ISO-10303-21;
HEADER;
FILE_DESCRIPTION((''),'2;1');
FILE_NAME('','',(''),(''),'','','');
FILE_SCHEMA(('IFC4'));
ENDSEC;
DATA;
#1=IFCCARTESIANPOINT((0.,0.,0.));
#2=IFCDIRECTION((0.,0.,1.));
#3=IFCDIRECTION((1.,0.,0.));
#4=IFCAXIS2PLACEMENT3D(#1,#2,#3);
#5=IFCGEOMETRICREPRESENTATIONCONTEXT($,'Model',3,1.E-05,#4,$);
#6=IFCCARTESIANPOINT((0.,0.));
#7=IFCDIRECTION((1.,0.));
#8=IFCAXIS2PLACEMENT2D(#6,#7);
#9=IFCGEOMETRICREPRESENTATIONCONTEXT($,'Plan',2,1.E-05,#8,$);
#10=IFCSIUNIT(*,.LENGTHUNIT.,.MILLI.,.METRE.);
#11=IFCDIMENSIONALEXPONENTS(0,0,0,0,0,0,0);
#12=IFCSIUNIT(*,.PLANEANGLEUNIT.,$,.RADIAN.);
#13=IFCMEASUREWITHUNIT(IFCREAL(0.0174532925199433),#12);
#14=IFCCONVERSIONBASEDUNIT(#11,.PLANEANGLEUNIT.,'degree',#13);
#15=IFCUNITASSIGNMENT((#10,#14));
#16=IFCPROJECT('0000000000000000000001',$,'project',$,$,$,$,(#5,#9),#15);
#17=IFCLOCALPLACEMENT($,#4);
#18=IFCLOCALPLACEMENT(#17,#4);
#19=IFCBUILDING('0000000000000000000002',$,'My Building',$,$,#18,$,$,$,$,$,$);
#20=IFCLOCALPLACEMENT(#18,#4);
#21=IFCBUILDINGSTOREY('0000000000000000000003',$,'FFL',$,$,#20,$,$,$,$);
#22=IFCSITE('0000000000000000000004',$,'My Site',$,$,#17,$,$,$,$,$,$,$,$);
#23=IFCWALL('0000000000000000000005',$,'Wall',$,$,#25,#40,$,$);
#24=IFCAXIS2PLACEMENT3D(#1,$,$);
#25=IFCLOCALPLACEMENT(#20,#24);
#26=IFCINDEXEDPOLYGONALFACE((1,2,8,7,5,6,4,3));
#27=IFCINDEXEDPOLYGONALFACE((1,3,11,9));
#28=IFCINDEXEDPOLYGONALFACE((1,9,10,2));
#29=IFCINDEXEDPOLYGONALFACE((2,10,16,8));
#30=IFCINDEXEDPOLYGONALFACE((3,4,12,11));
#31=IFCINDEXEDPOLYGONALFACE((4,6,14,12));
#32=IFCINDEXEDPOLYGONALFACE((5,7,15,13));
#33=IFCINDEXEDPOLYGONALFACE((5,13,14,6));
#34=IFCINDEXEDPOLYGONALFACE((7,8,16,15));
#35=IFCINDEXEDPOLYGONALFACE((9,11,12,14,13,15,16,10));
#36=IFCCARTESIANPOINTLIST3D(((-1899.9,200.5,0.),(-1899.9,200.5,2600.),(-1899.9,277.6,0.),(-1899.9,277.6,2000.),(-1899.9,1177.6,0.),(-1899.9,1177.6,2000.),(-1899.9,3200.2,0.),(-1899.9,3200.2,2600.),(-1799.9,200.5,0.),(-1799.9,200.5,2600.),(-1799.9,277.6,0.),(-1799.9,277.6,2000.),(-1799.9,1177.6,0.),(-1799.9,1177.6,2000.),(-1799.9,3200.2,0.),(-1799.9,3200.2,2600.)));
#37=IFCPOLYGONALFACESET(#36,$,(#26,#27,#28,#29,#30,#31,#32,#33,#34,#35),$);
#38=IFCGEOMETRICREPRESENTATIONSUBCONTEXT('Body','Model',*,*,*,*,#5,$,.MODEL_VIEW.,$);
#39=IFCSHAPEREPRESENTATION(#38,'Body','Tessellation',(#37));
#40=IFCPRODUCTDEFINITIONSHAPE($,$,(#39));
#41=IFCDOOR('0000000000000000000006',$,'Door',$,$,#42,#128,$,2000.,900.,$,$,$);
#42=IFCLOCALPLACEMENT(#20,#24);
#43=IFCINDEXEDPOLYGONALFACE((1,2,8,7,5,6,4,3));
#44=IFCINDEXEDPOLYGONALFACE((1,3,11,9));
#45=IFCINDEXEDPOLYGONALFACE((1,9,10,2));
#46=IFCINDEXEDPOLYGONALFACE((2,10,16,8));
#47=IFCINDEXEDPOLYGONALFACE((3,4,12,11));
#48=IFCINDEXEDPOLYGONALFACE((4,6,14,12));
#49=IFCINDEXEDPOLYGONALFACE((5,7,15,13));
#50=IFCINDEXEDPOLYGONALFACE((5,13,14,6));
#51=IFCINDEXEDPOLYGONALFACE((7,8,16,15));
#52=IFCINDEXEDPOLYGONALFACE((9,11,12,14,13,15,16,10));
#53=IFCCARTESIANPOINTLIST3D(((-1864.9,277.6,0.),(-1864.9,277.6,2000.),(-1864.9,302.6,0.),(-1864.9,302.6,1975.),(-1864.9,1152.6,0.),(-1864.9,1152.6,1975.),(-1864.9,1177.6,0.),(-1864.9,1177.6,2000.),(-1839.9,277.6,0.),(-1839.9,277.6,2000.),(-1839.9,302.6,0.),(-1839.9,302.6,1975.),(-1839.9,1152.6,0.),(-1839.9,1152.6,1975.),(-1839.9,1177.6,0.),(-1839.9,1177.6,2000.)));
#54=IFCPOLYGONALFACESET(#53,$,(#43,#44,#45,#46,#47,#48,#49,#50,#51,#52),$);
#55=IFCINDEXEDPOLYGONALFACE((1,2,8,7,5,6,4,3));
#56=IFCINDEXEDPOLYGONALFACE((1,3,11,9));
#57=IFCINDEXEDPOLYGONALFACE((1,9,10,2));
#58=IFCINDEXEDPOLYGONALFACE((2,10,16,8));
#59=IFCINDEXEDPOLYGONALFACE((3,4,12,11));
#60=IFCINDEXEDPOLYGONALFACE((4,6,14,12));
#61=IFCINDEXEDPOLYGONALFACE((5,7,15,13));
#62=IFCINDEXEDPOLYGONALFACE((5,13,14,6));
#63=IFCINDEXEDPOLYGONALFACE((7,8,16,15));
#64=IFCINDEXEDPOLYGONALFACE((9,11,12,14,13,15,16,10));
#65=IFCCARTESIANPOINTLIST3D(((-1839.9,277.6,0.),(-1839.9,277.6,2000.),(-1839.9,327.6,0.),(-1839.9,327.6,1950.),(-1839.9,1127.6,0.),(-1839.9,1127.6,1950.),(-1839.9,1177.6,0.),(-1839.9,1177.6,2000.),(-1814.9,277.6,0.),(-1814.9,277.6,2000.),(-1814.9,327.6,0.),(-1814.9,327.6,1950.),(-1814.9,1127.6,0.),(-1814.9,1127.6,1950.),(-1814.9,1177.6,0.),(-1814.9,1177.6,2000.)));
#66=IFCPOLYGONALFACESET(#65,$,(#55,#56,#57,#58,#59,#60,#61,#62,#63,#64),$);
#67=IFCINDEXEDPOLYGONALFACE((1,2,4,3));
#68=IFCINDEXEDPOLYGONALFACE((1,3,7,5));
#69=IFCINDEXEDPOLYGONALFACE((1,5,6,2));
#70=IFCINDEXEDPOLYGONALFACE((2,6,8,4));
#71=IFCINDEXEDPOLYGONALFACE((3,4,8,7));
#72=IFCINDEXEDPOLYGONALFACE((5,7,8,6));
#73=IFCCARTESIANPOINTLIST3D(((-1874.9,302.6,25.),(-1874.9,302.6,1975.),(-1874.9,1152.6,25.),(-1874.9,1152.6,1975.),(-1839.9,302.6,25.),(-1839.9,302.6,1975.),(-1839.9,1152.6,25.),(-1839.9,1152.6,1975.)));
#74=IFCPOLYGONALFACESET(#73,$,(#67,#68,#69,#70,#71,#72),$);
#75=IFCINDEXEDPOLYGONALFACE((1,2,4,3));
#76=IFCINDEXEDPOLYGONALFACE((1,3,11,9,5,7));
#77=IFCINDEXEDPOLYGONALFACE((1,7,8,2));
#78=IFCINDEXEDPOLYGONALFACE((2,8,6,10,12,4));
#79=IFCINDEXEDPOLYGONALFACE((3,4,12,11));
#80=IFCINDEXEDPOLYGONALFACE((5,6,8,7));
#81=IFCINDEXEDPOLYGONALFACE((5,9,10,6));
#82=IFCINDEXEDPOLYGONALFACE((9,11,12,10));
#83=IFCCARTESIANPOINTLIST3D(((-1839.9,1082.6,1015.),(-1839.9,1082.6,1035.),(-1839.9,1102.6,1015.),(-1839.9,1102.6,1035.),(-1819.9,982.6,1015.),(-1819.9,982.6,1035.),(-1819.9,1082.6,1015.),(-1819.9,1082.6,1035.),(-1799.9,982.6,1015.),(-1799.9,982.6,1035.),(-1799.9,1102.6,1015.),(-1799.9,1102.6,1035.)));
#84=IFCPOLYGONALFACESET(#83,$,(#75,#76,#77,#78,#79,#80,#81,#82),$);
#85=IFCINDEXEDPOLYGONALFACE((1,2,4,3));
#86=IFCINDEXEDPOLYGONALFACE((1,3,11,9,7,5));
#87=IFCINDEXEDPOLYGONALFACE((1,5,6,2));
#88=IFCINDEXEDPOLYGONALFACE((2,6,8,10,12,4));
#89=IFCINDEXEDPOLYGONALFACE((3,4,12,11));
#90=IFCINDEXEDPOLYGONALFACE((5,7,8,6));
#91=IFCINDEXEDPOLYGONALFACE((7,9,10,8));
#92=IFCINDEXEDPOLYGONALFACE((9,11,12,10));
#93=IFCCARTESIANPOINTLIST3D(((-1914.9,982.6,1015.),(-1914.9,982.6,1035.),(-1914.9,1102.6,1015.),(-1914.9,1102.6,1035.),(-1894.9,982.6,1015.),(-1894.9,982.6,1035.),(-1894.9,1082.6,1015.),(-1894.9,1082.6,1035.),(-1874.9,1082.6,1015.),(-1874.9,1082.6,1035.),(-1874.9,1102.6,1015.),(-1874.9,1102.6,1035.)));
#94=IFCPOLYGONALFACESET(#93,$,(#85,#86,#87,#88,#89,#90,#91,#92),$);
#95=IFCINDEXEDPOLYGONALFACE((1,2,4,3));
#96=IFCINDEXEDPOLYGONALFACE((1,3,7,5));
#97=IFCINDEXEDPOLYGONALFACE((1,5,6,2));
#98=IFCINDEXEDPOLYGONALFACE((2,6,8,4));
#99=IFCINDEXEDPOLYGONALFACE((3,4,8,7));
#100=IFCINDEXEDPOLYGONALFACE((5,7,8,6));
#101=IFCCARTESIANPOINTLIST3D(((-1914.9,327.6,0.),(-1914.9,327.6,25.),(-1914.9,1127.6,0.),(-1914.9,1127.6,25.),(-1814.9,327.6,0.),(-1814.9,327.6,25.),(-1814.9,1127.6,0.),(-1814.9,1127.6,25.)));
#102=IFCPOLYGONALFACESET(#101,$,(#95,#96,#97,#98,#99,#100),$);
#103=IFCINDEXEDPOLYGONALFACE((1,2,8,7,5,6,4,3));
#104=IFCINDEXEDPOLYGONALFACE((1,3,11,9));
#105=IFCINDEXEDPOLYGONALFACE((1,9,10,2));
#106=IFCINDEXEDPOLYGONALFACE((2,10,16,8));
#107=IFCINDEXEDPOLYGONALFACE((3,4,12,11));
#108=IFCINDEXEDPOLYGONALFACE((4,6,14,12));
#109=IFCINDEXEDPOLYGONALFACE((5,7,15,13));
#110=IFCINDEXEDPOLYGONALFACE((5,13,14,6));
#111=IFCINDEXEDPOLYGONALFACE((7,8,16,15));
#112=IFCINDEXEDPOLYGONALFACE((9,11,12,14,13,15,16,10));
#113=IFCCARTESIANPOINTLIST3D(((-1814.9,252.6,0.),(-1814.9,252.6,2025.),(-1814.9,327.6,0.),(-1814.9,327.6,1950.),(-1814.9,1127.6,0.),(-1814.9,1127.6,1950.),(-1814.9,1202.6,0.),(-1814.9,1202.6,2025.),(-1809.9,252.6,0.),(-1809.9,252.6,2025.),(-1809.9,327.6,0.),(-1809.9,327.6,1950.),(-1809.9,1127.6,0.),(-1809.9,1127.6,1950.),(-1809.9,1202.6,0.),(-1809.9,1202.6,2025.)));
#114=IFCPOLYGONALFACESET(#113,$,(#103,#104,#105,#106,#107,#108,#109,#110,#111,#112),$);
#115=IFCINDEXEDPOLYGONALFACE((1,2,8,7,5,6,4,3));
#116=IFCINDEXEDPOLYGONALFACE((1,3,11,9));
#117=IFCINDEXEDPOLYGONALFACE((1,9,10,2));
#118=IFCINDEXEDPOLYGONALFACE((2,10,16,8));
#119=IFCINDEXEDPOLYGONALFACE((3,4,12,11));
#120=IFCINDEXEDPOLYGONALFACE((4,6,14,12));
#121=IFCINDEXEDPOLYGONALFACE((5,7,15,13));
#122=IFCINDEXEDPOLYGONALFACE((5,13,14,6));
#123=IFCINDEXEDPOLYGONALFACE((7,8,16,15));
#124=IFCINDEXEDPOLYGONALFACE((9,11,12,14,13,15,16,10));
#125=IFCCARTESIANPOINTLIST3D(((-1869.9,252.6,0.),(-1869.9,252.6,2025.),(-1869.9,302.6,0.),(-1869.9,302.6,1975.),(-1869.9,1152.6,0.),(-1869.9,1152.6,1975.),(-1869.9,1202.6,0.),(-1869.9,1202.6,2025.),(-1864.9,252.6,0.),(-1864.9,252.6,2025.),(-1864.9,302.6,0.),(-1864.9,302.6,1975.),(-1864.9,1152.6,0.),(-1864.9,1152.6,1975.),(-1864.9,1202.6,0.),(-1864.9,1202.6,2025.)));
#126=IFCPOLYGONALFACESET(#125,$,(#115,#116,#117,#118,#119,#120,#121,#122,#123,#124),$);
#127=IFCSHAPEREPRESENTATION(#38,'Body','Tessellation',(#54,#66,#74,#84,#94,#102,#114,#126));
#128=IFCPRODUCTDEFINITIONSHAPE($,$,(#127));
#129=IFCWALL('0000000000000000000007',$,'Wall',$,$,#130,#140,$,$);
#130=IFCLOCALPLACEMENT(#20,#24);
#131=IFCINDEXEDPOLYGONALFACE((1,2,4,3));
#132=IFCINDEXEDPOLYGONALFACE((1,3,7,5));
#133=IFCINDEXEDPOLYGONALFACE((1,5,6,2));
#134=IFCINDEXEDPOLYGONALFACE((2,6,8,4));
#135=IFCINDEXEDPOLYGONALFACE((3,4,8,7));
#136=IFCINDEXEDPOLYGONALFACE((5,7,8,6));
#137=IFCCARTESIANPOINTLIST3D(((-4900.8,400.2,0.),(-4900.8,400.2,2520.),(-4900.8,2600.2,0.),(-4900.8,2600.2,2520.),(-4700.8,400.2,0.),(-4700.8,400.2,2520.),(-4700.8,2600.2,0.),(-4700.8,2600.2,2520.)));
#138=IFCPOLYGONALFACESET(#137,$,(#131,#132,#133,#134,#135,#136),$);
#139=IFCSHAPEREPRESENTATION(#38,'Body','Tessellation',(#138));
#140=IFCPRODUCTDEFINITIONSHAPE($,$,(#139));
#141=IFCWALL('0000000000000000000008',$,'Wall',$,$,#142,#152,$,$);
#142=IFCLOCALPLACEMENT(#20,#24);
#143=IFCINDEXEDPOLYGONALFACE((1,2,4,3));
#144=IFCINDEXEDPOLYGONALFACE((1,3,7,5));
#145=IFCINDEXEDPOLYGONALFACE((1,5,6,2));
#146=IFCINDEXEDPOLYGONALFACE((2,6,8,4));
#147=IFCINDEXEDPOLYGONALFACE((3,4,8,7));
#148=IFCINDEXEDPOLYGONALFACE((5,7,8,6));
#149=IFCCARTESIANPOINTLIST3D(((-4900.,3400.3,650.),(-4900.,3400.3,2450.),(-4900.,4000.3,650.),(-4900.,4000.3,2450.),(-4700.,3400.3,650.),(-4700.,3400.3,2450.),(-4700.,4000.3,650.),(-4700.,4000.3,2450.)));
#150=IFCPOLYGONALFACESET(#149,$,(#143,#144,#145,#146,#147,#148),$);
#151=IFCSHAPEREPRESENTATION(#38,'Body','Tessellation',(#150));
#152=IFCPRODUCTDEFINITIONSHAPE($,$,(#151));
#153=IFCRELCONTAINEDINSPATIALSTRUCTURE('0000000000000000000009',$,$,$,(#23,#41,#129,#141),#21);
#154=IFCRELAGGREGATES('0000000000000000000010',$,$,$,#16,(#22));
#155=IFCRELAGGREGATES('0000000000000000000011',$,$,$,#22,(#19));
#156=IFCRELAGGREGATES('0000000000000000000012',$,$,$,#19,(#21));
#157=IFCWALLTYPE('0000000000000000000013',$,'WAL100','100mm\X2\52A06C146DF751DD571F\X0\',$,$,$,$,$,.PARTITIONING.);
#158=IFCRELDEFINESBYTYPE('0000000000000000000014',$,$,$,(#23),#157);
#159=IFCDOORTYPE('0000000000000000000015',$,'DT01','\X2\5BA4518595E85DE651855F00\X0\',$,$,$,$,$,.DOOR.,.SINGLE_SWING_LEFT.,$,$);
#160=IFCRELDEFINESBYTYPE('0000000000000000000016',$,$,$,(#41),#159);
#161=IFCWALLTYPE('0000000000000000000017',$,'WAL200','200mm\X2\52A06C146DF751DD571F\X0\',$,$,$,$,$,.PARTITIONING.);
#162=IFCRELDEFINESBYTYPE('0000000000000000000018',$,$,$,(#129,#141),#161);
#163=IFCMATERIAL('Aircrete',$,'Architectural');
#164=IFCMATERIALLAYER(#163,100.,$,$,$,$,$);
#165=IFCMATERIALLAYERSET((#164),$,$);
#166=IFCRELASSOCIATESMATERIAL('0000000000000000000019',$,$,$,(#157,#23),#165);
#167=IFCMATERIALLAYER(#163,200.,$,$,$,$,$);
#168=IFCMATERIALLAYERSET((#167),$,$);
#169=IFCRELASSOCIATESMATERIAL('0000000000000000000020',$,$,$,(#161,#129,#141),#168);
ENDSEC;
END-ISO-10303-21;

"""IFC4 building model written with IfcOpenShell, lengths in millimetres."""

from ifc_helpers import new_model, entity, si_unit, converted_unit, frame, origin_with_axes, origin_2d_with_axis, place, context, subcontext, project, spatial, line, indexed_curve, outline, extrude, shape, source, transform, mapped, material, layer, layer_set, layer_usage, type_object, type_shapes, element, fill, save


model = new_model("IFC4")

# Units and contexts
model_context = context("Model", 3, precision=1e-05, world=origin_with_axes())
plan_context = context("Plan", 2, precision=1e-05, world=origin_2d_with_axis())
body_context_1 = subcontext(model_context, "Body", "Model", "MODEL_VIEW")
body_context_2 = subcontext(plan_context, "Body", "Plan", "PLAN_VIEW")
ifc_project = project(units=[si_unit("LENGTHUNIT", "METRE", prefix="MILLI"), converted_unit("PLANEANGLEUNIT", "degree", entity("IfcReal", 0.0174532925199433), si_unit("PLANEANGLEUNIT", "RADIAN"), dimensions=[0, 0, 0, 0, 0, 0, 0])], contexts=[model_context, plan_context])

# Site, building, storey
site_placement = place(None, origin_with_axes())
site = spatial("IfcSite", under=ifc_project, at=site_placement, Name="My Site")
building_placement = place(site_placement, origin_with_axes())
building = spatial("IfcBuilding", under=site, at=building_placement, Name="My Building")
storey_placement = place(building_placement, origin_with_axes())
storey = spatial("IfcBuildingStorey", under=building, at=storey_placement, Name="FFL")

# Shared definitions
ifc_material_1 = material(Name="Aircrete", Category="Architectural")

# Wall, opening, door
ifc_layer_1 = layer(ifc_material_1, 100.0)
ifc_layer_set_1 = layer_set([ifc_layer_1])
ifc_layer_usage_1 = layer_usage(ifc_layer_set_1, "AXIS2", "POSITIVE", 0.0)
wall_type_1 = type_object("IfcWallType", Name="WAL100", Description="100mm加气混凝土", PredefinedType="PARTITIONING", material=ifc_layer_set_1)
wall_1_placement = place(storey_placement, frame((-1899.9, 3200.2, 0.0), z_axis=(0.0, 0.0, 1.0), x_axis=(0.0, -1.0, 0.0)))
wall_1 = element("IfcWall", 1, at=wall_1_placement, inside=storey, type_object=wall_type_1, material=ifc_layer_usage_1, Name="Wall", context=body_context_1, shape_type="SweptSolid", body=[
    extrude(outline(indexed_curve([(0.0, 0.0), (0.0, 100.0), (2999.7, 100.0), (2999.7, 0.0)], segments=[line(1, 2, 3, 4, 1)])), origin_with_axes(), (0.0, 0.0, 1.0), 2600.0),
])
shared_shape_1 = source(origin_with_axes(), body_context_1, "Body", "SweptSolid", [
    extrude(outline(indexed_curve([(0.0, 0.0), (900.0, 0.0), (900.0, 2000.0), (0.0, 2000.0)], segments=[line(1, 2, 3, 4, 1)])), frame((0.0, -600.0, 0.0), z_axis=(0.0, -1.0, 0.0), x_axis=(1.0, 0.0, 0.0)), (0.0, 0.0, -1.0), 1200.0),
])
opening_1_placement = place(wall_1_placement, frame((2922.6, 85.0, 0.0), z_axis=(0.0, 0.0, 1.0), x_axis=(-1.0, 0.0, 0.0)))
opening_1 = element("IfcOpeningElement", 2, at=opening_1_placement, cuts=wall_1, PredefinedType="OPENING", context=body_context_1, shape_type="MappedRepresentation", body=[
    mapped(shared_shape_1, transform((0.0, 0.0, 0.0), x_axis=(1.0, 0.0, 0.0), y_axis=(0.0, 1.0, 0.0), z_axis=(0.0, 0.0, 1.0), scale=1.0)),
])
door_type = type_object("IfcDoorType", Name="DT01", Description="室内门左内开", OperationType="SINGLE_SWING_LEFT", PredefinedType="DOOR")
shared_shape_2 = source(origin_with_axes(), body_context_1, "Body", "SweptSolid", [
    extrude(outline(indexed_curve([(0.0, 0.0), (0.0, 2000.0), (900.0, 2000.0), (900.0, 0.0), (875.0, 0.0), (875.0, 1975.0), (25.0, 1975.0), (25.0, 0.0)], segments=[line(1, 2, 3, 4, 5, 6, 7, 8, 1)])), frame((0.0, 25.0, 0.0), z_axis=(0.0, -1.0, 0.0), x_axis=(1.0, 0.0, 0.0)), (0.0, 0.0, -1.0), 25.0),
    extrude(outline(indexed_curve([(0.0, 0.0), (0.0, 2000.0), (900.0, 2000.0), (900.0, 0.0), (850.0, 0.0), (850.0, 1950.0), (50.0, 1950.0), (50.0, 0.0)], segments=[line(1, 2, 3, 4, 5, 6, 7, 8, 1)])), frame((0.0, 0.0, 0.0), z_axis=(0.0, -1.0, 0.0), x_axis=(1.0, 0.0, 0.0)), (0.0, 0.0, -1.0), 25.0),
    extrude(outline(indexed_curve([(0.0, 0.0), (850.0, 0.0), (850.0, 35.0), (0.0, 35.0)], segments=[line(1, 2, 3, 4, 1)])), frame((25.0, 25.0, 25.0), z_axis=(0.0, 0.0, 1.0), x_axis=(1.0, 0.0, 0.0)), (0.0, 0.0, 1.0), 1950.0),
    extrude(outline(indexed_curve([(-20.0, 0.0), (-20.0, -20.0), (-120.0, -20.0), (-120.0, -40.0), (0.0, -40.0), (0.0, 0.0), (-20.0, 0.0)])), frame((825.0, 25.0, 1015.0), z_axis=(0.0, 0.0, 1.0), x_axis=(1.0, 0.0, 0.0)), (0.0, 0.0, 1.0), 20.0),
    extrude(outline(indexed_curve([(0.0, 0.0), (0.0, 40.0), (-120.0, 40.0), (-120.0, 20.0), (-20.0, 20.0), (-20.0, 0.0)], segments=[line(1, 2, 3, 4, 5, 6, 1)])), frame((825.0, 60.0, 1015.0), z_axis=(0.0, 0.0, 1.0), x_axis=(1.0, 0.0, 0.0)), (0.0, 0.0, 1.0), 20.0),
    extrude(outline(indexed_curve([(0.0, 0.0), (800.0, 0.0), (800.0, 100.0), (0.0, 100.0)], segments=[line(1, 2, 3, 4, 1)])), frame((50.0, 0.0, 0.0), z_axis=(0.0, 0.0, 1.0), x_axis=(1.0, 0.0, 0.0)), (0.0, 0.0, 1.0), 25.0),
    extrude(outline(indexed_curve([(0.0, 0.0), (0.0, 2025.0), (950.0, 2025.0), (950.0, 0.0), (875.0, 0.0), (875.0, 1950.0), (75.0, 1950.0), (75.0, 0.0)], segments=[line(1, 2, 3, 4, 5, 6, 7, 8, 1)])), frame((-25.0, -5.0, 0.0), z_axis=(0.0, -1.0, 0.0), x_axis=(1.0, 0.0, 0.0)), (0.0, 0.0, -1.0), 5.0),
    extrude(outline(indexed_curve([(0.0, 0.0), (0.0, 2025.0), (950.0, 2025.0), (950.0, 0.0), (900.0, 0.0), (900.0, 1975.0), (50.0, 1975.0), (50.0, 0.0)], segments=[line(1, 2, 3, 4, 5, 6, 7, 8, 1)])), frame((-25.0, 50.0, 0.0), z_axis=(0.0, -1.0, 0.0), x_axis=(1.0, 0.0, 0.0)), (0.0, 0.0, -1.0), 5.0),
])
shared_shape_3 = source(origin_with_axes(), body_context_2, "Body", "Curve2D", [
    entity("IfcIndexedPolyCurve", entity("IfcCartesianPointList2D", [[0.0, 0.0], [0.0, 50.0], [25.0, 50.0], [25.0, 25.0], [50.0, 25.0], [50.0, 0.0]]), [entity("IfcLineIndex", [1, 2, 3, 4, 5, 6, 1])]),
    entity("IfcIndexedPolyCurve", entity("IfcCartesianPointList2D", [[900.0, 0.0], [900.0, 50.0], [875.0, 50.0], [875.0, 25.0], [850.0, 25.0], [850.0, 0.0]]), [entity("IfcLineIndex", [1, 2, 3, 4, 5, 6, 1])]),
    entity("IfcTrimmedCurve", entity("IfcEllipse", entity("IfcAxis2Placement2D", entity("IfcCartesianPoint", [60.0, 50.0]), entity("IfcDirection", [1.0, 0.0])), 815.0, 850.0), [entity("IfcCartesianPoint", [875.0, 50.0])], [entity("IfcCartesianPoint", [60.0, 900.0])], True, "CARTESIAN"),
    entity("IfcIndexedPolyCurve", entity("IfcCartesianPointList2D", [[25.0, 50.0], [60.0, 50.0], [60.0, 900.0], [25.0, 900.0]]), [entity("IfcLineIndex", [1, 2, 3, 4, 1])]),
])
type_shapes(door_type, [shared_shape_2, shared_shape_3])
door_placement = place(opening_1_placement, frame((0.0, 0.0, 0.0), z_axis=(0.0, 0.0, 1.0), x_axis=(1.0, 0.0, 0.0)))
door = element("IfcDoor", 3, at=door_placement, inside=storey, type_object=door_type, Name="Door", OverallHeight=2000.0, OverallWidth=900.0, shapes=[
    shape(body_context_1, "Body", "MappedRepresentation", [mapped(shared_shape_2, transform((0.0, 0.0, 0.0), x_axis=(1.0, 0.0, 0.0), y_axis=(0.0, 1.0, 0.0), z_axis=(0.0, 0.0, 1.0), scale=1.0))]),
    shape(body_context_2, "Body", "MappedRepresentation", [mapped(shared_shape_3, transform((0.0, 0.0, 0.0), x_axis=(1.0, 0.0, 0.0), y_axis=(0.0, 1.0, 0.0), z_axis=(0.0, 0.0, 1.0), scale=1.0))]),
])
fill(opening_1, door)

# Walls
ifc_layer_2 = layer(ifc_material_1, 200.0)
ifc_layer_set_2 = layer_set([ifc_layer_2])
ifc_layer_usage_2 = layer_usage(ifc_layer_set_2, "AXIS2", "NEGATIVE", 0.0)
wall_type_2 = type_object("IfcWallType", Name="WAL200", Description="200mm加气混凝土", PredefinedType="PARTITIONING", material=ifc_layer_set_2)
wall_2_placement = place(storey_placement, frame((-4900.8, 400.2, 0.0), z_axis=(0.0, 0.0, 1.0), x_axis=(0.0, 1.0, 0.0)))
element("IfcWall", 4, at=wall_2_placement, inside=storey, type_object=wall_type_2, material=ifc_layer_usage_2, Name="Wall", context=body_context_1, shape_type="SweptSolid", body=[
    extrude(outline(indexed_curve([(0.0, -200.0), (0.0, 0.0), (2200.0, 0.0), (2200.0, -200.0)], segments=[line(1, 2, 3, 4, 1)])), origin_with_axes(), (0.0, 0.0, 1.0), 2520.0),
])
ifc_layer_usage_3 = layer_usage(ifc_layer_set_2, "AXIS2", "NEGATIVE", 0.0)
wall_3_placement = place(storey_placement, frame((-4900.0, 3400.3, 650.0), z_axis=(0.0, 0.0, 1.0), x_axis=(0.0, 1.0, 0.0)))
element("IfcWall", 5, at=wall_3_placement, inside=storey, type_object=wall_type_2, material=ifc_layer_usage_3, Name="Wall", context=body_context_1, shape_type="SweptSolid", body=[
    extrude(outline(indexed_curve([(0.0, -200.0), (0.0, 0.0), (600.0, 0.0), (600.0, -200.0)], segments=[line(1, 2, 3, 4, 1)])), origin_with_axes(), (0.0, 0.0, 1.0), 1800.0),
])

save(model, "model.ifc")
